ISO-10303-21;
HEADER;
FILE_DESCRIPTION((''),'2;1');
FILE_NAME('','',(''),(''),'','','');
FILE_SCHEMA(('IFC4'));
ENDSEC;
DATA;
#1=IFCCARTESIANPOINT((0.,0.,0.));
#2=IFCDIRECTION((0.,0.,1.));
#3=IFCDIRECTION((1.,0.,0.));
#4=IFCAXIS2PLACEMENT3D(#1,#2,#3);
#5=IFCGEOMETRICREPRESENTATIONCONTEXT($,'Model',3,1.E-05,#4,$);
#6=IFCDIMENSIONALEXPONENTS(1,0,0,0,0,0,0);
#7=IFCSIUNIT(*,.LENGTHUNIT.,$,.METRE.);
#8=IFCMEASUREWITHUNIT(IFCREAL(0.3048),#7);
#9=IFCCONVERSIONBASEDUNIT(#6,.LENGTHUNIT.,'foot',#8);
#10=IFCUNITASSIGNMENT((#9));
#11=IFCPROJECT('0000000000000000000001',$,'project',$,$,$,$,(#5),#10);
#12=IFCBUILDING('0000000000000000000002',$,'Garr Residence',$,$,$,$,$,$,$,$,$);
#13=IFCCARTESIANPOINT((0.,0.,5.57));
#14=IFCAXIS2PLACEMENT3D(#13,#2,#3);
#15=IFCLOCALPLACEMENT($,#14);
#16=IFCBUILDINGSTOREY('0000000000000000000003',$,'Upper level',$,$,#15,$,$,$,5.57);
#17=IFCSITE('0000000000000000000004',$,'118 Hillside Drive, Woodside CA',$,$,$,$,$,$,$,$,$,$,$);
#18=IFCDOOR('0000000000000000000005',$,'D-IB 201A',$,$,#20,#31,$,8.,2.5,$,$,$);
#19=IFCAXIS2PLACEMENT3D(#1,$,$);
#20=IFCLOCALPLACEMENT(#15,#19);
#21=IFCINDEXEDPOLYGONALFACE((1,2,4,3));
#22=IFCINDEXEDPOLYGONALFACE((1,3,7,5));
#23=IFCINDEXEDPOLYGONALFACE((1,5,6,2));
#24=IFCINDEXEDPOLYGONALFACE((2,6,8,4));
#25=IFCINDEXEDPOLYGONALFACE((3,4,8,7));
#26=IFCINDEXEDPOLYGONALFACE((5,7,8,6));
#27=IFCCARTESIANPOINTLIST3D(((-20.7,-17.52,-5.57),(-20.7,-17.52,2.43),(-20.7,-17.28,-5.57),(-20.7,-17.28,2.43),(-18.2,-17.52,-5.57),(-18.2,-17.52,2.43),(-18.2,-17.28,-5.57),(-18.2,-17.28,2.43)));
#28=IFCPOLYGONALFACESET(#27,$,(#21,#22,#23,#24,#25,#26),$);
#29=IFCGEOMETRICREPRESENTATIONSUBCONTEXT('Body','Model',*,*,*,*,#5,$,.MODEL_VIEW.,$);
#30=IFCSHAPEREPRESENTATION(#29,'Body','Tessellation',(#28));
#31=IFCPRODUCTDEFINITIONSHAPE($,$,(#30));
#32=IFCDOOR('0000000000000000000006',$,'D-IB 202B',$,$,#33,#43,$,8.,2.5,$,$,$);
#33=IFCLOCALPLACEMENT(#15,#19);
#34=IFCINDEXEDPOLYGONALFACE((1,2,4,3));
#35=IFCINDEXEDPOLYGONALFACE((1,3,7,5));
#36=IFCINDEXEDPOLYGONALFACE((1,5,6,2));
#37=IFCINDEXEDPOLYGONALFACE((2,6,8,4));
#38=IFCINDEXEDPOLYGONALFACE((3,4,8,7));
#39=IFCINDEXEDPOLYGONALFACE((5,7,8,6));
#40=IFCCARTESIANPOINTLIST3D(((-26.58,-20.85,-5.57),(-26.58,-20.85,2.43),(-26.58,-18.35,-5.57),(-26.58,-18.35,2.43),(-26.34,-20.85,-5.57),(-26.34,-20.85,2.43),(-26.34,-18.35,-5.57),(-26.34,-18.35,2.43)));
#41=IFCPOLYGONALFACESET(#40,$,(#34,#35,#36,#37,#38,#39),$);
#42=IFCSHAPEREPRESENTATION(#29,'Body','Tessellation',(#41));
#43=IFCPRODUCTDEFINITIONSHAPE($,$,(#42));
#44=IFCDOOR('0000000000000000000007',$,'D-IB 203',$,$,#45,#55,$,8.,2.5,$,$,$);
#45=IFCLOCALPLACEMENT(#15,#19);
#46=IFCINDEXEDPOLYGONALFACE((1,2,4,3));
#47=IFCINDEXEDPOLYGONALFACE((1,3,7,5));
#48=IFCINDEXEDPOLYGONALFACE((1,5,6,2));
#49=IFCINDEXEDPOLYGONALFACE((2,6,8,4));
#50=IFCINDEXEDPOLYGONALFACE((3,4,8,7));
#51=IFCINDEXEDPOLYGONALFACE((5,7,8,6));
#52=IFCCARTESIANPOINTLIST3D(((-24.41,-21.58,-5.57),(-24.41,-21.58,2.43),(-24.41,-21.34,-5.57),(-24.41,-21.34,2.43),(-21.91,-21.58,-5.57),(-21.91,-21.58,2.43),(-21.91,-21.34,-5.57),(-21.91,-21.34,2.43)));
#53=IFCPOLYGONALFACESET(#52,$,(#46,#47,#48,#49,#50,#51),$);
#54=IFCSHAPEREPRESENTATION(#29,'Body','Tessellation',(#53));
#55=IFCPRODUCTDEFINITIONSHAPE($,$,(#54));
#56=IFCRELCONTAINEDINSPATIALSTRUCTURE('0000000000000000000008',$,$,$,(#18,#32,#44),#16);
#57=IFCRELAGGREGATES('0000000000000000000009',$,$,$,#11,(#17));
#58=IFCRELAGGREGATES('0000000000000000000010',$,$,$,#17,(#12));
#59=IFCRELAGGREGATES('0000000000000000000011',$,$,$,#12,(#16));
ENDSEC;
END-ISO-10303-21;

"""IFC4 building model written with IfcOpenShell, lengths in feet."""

from ifc_helpers import new_model, entity, si_unit, converted_unit, frame, origin, origin_with_axes, place, context, subcontext, project, spatial, polyline, outline, extrude, element, save


model = new_model("IFC4")

# Units and contexts
model_context = context("Model", 3, precision=1e-05, world=origin_with_axes())
body_context = subcontext(model_context, "Body", "Model", "MODEL_VIEW")
ifc_project = project(units=[converted_unit("LENGTHUNIT", "foot", entity("IfcReal", 0.3048), si_unit("LENGTHUNIT", "METRE"), dimensions=[1, 0, 0, 0, 0, 0, 0])], contexts=[model_context])

# Site, building, storey
site = spatial("IfcSite", under=ifc_project, Name="118 Hillside Drive, Woodside CA")
building = spatial("IfcBuilding", under=site, Name="Garr Residence")
storey_placement = place(None, frame((0.0, 0.0, 5.57), z_axis=(0.0, 0.0, 1.0), x_axis=(1.0, 0.0, 0.0)))
storey = spatial("IfcBuildingStorey", under=building, at=storey_placement, Name="Upper level", Elevation=5.57)

# Doors
for number, where, z_axis, x_axis, name in (
    (1, (-19.45, -17.4, -5.57), (0.0, 0.0, 1.0), (1.0, 0.0, 0.0), "D-IB 201A"),
    (2, (-26.46, -19.6, -5.57), (0.0, 0.0, 1.0), (0.0, 1.0, 0.0), "D-IB 202B"),
    (3, (-23.16, -21.46, -5.57), (0.0, 0.0, 1.0), (1.0, 0.0, 0.0), "D-IB 203"),
):
    element("IfcDoor", number, at=place(storey_placement, frame(where, z_axis=z_axis, x_axis=x_axis)), inside=storey, Name=name, OverallHeight=8.0, OverallWidth=2.5, context=body_context, shape_type="SweptSolid", body=[
        extrude(outline(polyline([(-1.25, -0.12), (1.25, -0.12), (1.25, 0.12), (-1.25, 0.12), (-1.25, -0.12)])), origin(), (0.0, 0.0, 1.0), 8.0),
    ])

save(model, "model.ifc")
